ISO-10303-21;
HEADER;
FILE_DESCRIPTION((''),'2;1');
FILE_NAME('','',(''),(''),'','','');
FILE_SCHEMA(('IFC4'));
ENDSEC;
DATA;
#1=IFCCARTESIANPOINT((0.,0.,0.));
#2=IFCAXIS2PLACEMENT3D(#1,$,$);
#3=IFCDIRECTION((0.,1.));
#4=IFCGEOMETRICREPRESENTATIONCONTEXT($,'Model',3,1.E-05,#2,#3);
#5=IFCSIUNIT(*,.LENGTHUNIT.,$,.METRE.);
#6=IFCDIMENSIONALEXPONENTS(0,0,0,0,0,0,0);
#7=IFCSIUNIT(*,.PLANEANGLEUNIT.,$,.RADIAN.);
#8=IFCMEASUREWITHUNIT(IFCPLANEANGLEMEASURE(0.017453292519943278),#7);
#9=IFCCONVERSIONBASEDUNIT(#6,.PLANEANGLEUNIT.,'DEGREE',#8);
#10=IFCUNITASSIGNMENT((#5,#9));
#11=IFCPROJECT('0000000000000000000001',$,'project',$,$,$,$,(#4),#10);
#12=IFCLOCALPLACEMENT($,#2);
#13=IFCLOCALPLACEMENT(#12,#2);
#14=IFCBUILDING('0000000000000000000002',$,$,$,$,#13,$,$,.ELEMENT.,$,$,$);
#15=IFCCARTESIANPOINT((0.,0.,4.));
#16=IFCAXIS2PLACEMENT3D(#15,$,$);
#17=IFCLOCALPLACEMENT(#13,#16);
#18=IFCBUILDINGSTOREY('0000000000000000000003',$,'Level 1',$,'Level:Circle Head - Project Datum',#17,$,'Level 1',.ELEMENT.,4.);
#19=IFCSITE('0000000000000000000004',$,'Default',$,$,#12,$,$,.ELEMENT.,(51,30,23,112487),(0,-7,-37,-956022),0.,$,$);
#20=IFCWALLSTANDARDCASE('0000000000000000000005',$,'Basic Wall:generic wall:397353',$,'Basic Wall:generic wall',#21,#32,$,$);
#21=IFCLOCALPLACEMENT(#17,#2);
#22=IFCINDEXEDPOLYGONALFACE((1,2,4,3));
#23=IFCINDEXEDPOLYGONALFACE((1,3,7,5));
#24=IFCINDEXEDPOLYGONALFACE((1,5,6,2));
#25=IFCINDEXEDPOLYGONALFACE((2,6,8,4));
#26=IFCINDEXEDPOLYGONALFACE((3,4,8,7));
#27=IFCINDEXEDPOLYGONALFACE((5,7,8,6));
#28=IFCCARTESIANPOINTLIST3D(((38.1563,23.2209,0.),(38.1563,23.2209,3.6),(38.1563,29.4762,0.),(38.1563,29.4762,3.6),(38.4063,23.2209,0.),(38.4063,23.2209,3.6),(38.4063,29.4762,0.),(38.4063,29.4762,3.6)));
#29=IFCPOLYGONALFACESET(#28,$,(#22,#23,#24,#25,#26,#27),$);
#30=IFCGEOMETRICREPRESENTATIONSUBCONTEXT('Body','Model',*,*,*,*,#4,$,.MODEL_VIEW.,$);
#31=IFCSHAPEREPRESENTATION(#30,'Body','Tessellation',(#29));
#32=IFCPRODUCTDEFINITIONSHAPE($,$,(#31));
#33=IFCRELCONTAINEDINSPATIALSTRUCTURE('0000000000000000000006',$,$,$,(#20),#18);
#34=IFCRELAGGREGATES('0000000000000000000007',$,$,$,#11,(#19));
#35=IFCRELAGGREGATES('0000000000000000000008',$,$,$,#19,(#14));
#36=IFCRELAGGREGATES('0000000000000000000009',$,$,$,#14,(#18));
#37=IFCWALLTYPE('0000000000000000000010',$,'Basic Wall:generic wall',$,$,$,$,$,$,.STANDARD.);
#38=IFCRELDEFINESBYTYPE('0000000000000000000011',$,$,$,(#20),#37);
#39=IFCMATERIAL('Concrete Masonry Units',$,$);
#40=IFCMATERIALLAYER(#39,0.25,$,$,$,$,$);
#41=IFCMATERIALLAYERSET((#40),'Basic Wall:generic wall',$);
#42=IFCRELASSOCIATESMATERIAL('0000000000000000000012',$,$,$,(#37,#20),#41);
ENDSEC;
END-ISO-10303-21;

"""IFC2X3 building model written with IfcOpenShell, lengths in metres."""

from ifc_helpers import new_model, entity, si_unit, converted_unit, direction, frame, frame_2d, origin, place, context, subcontext, project, spatial, rectangle, extrude, material, layer, layer_set, layer_usage, type_object, element, save


model = new_model("IFC2X3")

# Units and contexts
model_context = context("Model", 3, precision=1e-05, world=origin(), true_north=direction((0.0, 1.0)))
body_context = subcontext(model_context, "Body", "Model", "MODEL_VIEW")
ifc_project = project(units=[si_unit("LENGTHUNIT", "METRE"), converted_unit("PLANEANGLEUNIT", "DEGREE", entity("IfcPlaneAngleMeasure", 0.017453292519943278), si_unit("PLANEANGLEUNIT", "RADIAN"), dimensions=[0, 0, 0, 0, 0, 0, 0])], contexts=[model_context])

# Site, building, storey
site_placement = place(None, origin())
site = spatial("IfcSite", under=ifc_project, at=site_placement, Name="Default", CompositionType="ELEMENT", RefLatitude=(51, 30, 23, 112487), RefLongitude=(0, -7, -37, -956022), RefElevation=0.0)
building_placement = place(site_placement, origin())
building = spatial("IfcBuilding", under=site, at=building_placement, CompositionType="ELEMENT")
storey_placement = place(building_placement, frame((0.0, 0.0, 4.0)))
storey = spatial("IfcBuildingStorey", under=building, at=storey_placement, Name="Level 1", ObjectType="Level:Circle Head - Project Datum", LongName="Level 1", CompositionType="ELEMENT", Elevation=4.0)

# Shared definitions
ifc_material = material(Name="Concrete Masonry Units")
ifc_layer = layer(ifc_material, 0.25)
ifc_layer_set = layer_set([ifc_layer], Name="Basic Wall:generic wall")
wall_type = type_object("IfcWallType", Name="Basic Wall:generic wall", PredefinedType="STANDARD", material=ifc_layer_set)

# Wall
ifc_layer_usage_1 = layer_usage(ifc_layer_set, "AXIS2", "NEGATIVE", 0.125)
wall_1_placement = place(storey_placement, frame((38.2813, 23.2209, 0.0), z_axis=(0.0, 0.0, 1.0), x_axis=(0.0, 1.0, 0.0)))
element("IfcWallStandardCase", 1, at=wall_1_placement, inside=storey, type_object=wall_type, material=ifc_layer_usage_1, Name="Basic Wall:generic wall:397353", ObjectType="Basic Wall:generic wall", context=body_context, shape_type="SweptSolid", body=[
    extrude(rectangle(XDim=6.2553, YDim=0.25, at=frame_2d((3.1276, 0.0), x_axis=(-1.0, 0.0))), origin(), (0.0, 0.0, 1.0), 3.6),
])

save(model, "model.ifc")
